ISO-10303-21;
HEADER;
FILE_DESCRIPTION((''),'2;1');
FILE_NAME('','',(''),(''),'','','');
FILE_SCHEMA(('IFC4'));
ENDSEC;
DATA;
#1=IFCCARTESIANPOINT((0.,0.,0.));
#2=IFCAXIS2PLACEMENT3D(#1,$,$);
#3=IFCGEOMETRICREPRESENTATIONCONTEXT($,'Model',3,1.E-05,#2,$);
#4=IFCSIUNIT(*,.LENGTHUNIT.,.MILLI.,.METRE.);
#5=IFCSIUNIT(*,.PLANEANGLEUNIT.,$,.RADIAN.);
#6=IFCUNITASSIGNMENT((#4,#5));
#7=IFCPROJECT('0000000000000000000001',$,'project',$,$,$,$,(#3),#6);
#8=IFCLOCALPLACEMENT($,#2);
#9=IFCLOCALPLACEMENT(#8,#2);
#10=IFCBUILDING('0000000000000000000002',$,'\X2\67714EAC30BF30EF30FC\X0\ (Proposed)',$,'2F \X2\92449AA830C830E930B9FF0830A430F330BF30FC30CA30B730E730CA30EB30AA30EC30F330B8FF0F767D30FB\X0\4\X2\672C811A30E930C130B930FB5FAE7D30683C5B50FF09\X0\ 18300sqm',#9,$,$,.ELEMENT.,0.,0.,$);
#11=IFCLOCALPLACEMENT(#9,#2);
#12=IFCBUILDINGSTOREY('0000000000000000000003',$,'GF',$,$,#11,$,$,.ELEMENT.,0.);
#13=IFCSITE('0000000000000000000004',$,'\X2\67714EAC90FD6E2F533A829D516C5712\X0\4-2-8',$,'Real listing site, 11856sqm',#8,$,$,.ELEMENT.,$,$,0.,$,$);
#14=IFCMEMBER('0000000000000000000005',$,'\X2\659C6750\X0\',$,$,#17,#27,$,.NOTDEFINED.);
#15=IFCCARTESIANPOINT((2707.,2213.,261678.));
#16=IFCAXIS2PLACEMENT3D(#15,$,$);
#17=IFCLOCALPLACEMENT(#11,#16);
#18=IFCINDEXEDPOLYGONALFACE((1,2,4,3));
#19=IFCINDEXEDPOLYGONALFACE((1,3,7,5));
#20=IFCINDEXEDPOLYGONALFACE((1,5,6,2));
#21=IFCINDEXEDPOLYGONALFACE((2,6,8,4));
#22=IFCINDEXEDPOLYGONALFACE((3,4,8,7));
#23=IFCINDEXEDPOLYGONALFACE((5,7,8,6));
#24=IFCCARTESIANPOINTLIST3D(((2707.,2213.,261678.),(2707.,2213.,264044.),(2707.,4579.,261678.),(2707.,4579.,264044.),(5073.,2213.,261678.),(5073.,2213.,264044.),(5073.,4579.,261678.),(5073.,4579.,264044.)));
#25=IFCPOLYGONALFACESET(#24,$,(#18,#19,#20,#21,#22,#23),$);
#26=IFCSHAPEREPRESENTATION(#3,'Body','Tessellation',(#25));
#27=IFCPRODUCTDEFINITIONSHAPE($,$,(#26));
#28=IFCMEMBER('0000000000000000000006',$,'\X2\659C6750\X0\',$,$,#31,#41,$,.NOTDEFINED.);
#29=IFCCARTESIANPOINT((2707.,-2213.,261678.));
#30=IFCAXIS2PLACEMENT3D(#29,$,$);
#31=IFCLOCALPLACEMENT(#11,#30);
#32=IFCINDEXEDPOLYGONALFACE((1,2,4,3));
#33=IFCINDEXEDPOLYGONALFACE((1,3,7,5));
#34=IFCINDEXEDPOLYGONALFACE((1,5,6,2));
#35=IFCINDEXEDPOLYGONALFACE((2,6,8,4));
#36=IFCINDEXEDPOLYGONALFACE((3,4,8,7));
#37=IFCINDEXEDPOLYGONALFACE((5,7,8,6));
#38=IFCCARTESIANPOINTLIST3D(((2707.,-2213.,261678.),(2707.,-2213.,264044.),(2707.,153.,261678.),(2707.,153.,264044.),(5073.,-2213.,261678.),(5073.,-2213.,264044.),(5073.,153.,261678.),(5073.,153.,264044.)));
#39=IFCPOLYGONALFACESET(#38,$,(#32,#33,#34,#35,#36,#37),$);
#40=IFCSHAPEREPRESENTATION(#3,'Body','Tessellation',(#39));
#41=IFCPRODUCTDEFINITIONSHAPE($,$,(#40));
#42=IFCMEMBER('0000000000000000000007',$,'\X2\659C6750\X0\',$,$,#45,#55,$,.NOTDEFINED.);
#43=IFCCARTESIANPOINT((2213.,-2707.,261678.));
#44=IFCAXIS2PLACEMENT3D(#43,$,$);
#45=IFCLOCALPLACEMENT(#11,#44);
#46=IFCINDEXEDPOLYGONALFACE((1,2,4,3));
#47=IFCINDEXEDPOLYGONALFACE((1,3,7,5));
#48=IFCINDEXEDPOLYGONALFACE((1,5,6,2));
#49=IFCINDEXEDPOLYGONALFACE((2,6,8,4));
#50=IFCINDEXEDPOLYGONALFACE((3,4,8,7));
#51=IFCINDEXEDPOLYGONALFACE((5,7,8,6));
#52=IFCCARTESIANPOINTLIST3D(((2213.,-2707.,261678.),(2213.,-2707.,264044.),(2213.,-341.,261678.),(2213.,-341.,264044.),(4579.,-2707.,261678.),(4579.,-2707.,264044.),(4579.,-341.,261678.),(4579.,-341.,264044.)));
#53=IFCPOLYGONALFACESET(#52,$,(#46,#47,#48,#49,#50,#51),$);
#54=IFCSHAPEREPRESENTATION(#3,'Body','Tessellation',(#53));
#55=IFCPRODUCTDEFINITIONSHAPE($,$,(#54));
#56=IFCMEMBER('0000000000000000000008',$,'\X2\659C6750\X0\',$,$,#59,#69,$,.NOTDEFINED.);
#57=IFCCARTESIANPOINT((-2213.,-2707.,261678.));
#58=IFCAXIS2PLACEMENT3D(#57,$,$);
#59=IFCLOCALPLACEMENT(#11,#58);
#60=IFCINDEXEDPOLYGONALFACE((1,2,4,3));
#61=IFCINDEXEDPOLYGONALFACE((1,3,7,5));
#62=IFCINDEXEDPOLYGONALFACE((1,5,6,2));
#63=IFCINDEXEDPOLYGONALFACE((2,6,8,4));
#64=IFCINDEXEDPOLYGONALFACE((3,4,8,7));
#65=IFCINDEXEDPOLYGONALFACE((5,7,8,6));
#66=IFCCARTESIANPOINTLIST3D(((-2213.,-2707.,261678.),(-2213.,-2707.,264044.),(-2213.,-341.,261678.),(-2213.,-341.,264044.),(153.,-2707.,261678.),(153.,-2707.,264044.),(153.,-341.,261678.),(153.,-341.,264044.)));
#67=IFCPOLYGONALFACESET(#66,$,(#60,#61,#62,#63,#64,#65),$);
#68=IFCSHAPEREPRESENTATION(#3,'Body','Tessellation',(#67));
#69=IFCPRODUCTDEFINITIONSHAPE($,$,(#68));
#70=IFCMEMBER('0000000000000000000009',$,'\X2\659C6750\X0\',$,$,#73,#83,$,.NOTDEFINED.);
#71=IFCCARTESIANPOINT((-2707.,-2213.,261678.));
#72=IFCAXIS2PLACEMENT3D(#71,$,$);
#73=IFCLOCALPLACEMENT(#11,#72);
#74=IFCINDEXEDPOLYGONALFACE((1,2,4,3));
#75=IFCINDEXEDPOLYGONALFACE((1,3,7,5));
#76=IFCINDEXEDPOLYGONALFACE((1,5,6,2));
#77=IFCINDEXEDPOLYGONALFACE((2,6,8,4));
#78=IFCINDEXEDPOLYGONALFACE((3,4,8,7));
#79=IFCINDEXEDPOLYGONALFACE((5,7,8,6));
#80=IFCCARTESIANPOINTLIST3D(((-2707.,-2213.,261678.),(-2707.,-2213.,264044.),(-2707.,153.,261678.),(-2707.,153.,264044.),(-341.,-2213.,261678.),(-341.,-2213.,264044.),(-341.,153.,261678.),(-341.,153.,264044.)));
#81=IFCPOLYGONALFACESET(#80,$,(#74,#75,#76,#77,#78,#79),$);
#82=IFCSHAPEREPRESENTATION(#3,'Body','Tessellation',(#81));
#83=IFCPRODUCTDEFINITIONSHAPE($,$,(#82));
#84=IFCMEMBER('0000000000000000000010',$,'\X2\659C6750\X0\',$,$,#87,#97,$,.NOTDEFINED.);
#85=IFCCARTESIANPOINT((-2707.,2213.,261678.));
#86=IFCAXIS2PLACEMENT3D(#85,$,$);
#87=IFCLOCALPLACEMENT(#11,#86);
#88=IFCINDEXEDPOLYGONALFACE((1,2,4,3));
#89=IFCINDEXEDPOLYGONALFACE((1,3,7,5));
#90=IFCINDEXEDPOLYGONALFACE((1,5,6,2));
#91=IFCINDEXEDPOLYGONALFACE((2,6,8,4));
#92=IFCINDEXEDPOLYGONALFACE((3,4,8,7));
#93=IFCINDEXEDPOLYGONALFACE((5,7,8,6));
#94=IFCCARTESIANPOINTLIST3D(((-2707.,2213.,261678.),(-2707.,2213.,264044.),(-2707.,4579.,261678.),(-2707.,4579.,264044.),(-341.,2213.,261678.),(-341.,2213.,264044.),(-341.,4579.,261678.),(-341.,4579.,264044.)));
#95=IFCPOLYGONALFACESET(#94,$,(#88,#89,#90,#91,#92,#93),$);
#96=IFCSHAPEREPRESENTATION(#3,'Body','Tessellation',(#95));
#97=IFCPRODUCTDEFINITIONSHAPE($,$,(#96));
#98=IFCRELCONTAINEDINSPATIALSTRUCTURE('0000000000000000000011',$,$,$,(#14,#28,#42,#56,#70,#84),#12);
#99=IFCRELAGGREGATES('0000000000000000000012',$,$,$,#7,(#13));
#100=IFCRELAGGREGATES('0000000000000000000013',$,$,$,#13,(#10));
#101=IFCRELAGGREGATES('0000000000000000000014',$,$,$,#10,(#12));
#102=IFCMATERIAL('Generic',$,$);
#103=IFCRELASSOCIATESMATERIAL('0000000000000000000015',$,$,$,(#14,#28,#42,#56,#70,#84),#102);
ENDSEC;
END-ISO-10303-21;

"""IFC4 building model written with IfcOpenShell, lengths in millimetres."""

from ifc_helpers import new_model, si_unit, frame, frame_2d, origin, place, context, project, spatial, rectangle, extrude, material, element, save


model = new_model("IFC4")

# Units and contexts
model_context = context("Model", 3, precision=1e-05, world=origin())
ifc_project = project(units=[si_unit("LENGTHUNIT", "METRE", prefix="MILLI"), si_unit("PLANEANGLEUNIT", "RADIAN")], contexts=[model_context])

# Site, building, storey
site_placement = place(None, origin())
site = spatial("IfcSite", under=ifc_project, at=site_placement, Name="東京都港区芝公園4-2-8", ObjectType="Real listing site, 11856sqm", CompositionType="ELEMENT", RefElevation=0.0)
building_placement = place(site_placement, origin())
building = spatial("IfcBuilding", under=site, at=building_placement, Name="東京タワー (Proposed)", ObjectType="2F 鉄骨トラス（インターナショナルオレンジ／白・4本脚ラチス・微細格子） 18300sqm", CompositionType="ELEMENT", ElevationOfRefHeight=0.0, ElevationOfTerrain=0.0)
storey_placement = place(building_placement, origin())
storey = spatial("IfcBuildingStorey", under=building, at=storey_placement, Name="GF", CompositionType="ELEMENT", Elevation=0.0)

# Members
ifc_material = material(Name="Generic")
member_1_placement = place(storey_placement, frame((2707.0, 2213.0, 261678.0)))
element("IfcMember", 1, at=member_1_placement, inside=storey, material=ifc_material, Name="斜材", PredefinedType="NOTDEFINED", context=model_context, shape_type="SweptSolid", body=[
    extrude(rectangle(XDim=2366.0, YDim=2366.0, at=frame_2d((1183.0, 1183.0))), frame((2707.0, 2213.0, 261678.0)), (0.0, 0.0, 1.0), 2366.0),
])
member_2_placement = place(storey_placement, frame((2707.0, -2213.0, 261678.0)))
element("IfcMember", 2, at=member_2_placement, inside=storey, material=ifc_material, Name="斜材", PredefinedType="NOTDEFINED", context=model_context, shape_type="SweptSolid", body=[
    extrude(rectangle(XDim=2366.0, YDim=2366.0, at=frame_2d((1183.0, 1183.0))), frame((2707.0, -2213.0, 261678.0)), (0.0, 0.0, 1.0), 2366.0),
])
member_3_placement = place(storey_placement, frame((2213.0, -2707.0, 261678.0)))
element("IfcMember", 3, at=member_3_placement, inside=storey, material=ifc_material, Name="斜材", PredefinedType="NOTDEFINED", context=model_context, shape_type="SweptSolid", body=[
    extrude(rectangle(XDim=2366.0, YDim=2366.0, at=frame_2d((1183.0, 1183.0))), frame((2213.0, -2707.0, 261678.0)), (0.0, 0.0, 1.0), 2366.0),
])
member_4_placement = place(storey_placement, frame((-2213.0, -2707.0, 261678.0)))
element("IfcMember", 4, at=member_4_placement, inside=storey, material=ifc_material, Name="斜材", PredefinedType="NOTDEFINED", context=model_context, shape_type="SweptSolid", body=[
    extrude(rectangle(XDim=2366.0, YDim=2366.0, at=frame_2d((1183.0, 1183.0))), frame((-2213.0, -2707.0, 261678.0)), (0.0, 0.0, 1.0), 2366.0),
])
member_5_placement = place(storey_placement, frame((-2707.0, -2213.0, 261678.0)))
element("IfcMember", 5, at=member_5_placement, inside=storey, material=ifc_material, Name="斜材", PredefinedType="NOTDEFINED", context=model_context, shape_type="SweptSolid", body=[
    extrude(rectangle(XDim=2366.0, YDim=2366.0, at=frame_2d((1183.0, 1183.0))), frame((-2707.0, -2213.0, 261678.0)), (0.0, 0.0, 1.0), 2366.0),
])
member_6_placement = place(storey_placement, frame((-2707.0, 2213.0, 261678.0)))
element("IfcMember", 6, at=member_6_placement, inside=storey, material=ifc_material, Name="斜材", PredefinedType="NOTDEFINED", context=model_context, shape_type="SweptSolid", body=[
    extrude(rectangle(XDim=2366.0, YDim=2366.0, at=frame_2d((1183.0, 1183.0))), frame((-2707.0, 2213.0, 261678.0)), (0.0, 0.0, 1.0), 2366.0),
])

save(model, "model.ifc")
